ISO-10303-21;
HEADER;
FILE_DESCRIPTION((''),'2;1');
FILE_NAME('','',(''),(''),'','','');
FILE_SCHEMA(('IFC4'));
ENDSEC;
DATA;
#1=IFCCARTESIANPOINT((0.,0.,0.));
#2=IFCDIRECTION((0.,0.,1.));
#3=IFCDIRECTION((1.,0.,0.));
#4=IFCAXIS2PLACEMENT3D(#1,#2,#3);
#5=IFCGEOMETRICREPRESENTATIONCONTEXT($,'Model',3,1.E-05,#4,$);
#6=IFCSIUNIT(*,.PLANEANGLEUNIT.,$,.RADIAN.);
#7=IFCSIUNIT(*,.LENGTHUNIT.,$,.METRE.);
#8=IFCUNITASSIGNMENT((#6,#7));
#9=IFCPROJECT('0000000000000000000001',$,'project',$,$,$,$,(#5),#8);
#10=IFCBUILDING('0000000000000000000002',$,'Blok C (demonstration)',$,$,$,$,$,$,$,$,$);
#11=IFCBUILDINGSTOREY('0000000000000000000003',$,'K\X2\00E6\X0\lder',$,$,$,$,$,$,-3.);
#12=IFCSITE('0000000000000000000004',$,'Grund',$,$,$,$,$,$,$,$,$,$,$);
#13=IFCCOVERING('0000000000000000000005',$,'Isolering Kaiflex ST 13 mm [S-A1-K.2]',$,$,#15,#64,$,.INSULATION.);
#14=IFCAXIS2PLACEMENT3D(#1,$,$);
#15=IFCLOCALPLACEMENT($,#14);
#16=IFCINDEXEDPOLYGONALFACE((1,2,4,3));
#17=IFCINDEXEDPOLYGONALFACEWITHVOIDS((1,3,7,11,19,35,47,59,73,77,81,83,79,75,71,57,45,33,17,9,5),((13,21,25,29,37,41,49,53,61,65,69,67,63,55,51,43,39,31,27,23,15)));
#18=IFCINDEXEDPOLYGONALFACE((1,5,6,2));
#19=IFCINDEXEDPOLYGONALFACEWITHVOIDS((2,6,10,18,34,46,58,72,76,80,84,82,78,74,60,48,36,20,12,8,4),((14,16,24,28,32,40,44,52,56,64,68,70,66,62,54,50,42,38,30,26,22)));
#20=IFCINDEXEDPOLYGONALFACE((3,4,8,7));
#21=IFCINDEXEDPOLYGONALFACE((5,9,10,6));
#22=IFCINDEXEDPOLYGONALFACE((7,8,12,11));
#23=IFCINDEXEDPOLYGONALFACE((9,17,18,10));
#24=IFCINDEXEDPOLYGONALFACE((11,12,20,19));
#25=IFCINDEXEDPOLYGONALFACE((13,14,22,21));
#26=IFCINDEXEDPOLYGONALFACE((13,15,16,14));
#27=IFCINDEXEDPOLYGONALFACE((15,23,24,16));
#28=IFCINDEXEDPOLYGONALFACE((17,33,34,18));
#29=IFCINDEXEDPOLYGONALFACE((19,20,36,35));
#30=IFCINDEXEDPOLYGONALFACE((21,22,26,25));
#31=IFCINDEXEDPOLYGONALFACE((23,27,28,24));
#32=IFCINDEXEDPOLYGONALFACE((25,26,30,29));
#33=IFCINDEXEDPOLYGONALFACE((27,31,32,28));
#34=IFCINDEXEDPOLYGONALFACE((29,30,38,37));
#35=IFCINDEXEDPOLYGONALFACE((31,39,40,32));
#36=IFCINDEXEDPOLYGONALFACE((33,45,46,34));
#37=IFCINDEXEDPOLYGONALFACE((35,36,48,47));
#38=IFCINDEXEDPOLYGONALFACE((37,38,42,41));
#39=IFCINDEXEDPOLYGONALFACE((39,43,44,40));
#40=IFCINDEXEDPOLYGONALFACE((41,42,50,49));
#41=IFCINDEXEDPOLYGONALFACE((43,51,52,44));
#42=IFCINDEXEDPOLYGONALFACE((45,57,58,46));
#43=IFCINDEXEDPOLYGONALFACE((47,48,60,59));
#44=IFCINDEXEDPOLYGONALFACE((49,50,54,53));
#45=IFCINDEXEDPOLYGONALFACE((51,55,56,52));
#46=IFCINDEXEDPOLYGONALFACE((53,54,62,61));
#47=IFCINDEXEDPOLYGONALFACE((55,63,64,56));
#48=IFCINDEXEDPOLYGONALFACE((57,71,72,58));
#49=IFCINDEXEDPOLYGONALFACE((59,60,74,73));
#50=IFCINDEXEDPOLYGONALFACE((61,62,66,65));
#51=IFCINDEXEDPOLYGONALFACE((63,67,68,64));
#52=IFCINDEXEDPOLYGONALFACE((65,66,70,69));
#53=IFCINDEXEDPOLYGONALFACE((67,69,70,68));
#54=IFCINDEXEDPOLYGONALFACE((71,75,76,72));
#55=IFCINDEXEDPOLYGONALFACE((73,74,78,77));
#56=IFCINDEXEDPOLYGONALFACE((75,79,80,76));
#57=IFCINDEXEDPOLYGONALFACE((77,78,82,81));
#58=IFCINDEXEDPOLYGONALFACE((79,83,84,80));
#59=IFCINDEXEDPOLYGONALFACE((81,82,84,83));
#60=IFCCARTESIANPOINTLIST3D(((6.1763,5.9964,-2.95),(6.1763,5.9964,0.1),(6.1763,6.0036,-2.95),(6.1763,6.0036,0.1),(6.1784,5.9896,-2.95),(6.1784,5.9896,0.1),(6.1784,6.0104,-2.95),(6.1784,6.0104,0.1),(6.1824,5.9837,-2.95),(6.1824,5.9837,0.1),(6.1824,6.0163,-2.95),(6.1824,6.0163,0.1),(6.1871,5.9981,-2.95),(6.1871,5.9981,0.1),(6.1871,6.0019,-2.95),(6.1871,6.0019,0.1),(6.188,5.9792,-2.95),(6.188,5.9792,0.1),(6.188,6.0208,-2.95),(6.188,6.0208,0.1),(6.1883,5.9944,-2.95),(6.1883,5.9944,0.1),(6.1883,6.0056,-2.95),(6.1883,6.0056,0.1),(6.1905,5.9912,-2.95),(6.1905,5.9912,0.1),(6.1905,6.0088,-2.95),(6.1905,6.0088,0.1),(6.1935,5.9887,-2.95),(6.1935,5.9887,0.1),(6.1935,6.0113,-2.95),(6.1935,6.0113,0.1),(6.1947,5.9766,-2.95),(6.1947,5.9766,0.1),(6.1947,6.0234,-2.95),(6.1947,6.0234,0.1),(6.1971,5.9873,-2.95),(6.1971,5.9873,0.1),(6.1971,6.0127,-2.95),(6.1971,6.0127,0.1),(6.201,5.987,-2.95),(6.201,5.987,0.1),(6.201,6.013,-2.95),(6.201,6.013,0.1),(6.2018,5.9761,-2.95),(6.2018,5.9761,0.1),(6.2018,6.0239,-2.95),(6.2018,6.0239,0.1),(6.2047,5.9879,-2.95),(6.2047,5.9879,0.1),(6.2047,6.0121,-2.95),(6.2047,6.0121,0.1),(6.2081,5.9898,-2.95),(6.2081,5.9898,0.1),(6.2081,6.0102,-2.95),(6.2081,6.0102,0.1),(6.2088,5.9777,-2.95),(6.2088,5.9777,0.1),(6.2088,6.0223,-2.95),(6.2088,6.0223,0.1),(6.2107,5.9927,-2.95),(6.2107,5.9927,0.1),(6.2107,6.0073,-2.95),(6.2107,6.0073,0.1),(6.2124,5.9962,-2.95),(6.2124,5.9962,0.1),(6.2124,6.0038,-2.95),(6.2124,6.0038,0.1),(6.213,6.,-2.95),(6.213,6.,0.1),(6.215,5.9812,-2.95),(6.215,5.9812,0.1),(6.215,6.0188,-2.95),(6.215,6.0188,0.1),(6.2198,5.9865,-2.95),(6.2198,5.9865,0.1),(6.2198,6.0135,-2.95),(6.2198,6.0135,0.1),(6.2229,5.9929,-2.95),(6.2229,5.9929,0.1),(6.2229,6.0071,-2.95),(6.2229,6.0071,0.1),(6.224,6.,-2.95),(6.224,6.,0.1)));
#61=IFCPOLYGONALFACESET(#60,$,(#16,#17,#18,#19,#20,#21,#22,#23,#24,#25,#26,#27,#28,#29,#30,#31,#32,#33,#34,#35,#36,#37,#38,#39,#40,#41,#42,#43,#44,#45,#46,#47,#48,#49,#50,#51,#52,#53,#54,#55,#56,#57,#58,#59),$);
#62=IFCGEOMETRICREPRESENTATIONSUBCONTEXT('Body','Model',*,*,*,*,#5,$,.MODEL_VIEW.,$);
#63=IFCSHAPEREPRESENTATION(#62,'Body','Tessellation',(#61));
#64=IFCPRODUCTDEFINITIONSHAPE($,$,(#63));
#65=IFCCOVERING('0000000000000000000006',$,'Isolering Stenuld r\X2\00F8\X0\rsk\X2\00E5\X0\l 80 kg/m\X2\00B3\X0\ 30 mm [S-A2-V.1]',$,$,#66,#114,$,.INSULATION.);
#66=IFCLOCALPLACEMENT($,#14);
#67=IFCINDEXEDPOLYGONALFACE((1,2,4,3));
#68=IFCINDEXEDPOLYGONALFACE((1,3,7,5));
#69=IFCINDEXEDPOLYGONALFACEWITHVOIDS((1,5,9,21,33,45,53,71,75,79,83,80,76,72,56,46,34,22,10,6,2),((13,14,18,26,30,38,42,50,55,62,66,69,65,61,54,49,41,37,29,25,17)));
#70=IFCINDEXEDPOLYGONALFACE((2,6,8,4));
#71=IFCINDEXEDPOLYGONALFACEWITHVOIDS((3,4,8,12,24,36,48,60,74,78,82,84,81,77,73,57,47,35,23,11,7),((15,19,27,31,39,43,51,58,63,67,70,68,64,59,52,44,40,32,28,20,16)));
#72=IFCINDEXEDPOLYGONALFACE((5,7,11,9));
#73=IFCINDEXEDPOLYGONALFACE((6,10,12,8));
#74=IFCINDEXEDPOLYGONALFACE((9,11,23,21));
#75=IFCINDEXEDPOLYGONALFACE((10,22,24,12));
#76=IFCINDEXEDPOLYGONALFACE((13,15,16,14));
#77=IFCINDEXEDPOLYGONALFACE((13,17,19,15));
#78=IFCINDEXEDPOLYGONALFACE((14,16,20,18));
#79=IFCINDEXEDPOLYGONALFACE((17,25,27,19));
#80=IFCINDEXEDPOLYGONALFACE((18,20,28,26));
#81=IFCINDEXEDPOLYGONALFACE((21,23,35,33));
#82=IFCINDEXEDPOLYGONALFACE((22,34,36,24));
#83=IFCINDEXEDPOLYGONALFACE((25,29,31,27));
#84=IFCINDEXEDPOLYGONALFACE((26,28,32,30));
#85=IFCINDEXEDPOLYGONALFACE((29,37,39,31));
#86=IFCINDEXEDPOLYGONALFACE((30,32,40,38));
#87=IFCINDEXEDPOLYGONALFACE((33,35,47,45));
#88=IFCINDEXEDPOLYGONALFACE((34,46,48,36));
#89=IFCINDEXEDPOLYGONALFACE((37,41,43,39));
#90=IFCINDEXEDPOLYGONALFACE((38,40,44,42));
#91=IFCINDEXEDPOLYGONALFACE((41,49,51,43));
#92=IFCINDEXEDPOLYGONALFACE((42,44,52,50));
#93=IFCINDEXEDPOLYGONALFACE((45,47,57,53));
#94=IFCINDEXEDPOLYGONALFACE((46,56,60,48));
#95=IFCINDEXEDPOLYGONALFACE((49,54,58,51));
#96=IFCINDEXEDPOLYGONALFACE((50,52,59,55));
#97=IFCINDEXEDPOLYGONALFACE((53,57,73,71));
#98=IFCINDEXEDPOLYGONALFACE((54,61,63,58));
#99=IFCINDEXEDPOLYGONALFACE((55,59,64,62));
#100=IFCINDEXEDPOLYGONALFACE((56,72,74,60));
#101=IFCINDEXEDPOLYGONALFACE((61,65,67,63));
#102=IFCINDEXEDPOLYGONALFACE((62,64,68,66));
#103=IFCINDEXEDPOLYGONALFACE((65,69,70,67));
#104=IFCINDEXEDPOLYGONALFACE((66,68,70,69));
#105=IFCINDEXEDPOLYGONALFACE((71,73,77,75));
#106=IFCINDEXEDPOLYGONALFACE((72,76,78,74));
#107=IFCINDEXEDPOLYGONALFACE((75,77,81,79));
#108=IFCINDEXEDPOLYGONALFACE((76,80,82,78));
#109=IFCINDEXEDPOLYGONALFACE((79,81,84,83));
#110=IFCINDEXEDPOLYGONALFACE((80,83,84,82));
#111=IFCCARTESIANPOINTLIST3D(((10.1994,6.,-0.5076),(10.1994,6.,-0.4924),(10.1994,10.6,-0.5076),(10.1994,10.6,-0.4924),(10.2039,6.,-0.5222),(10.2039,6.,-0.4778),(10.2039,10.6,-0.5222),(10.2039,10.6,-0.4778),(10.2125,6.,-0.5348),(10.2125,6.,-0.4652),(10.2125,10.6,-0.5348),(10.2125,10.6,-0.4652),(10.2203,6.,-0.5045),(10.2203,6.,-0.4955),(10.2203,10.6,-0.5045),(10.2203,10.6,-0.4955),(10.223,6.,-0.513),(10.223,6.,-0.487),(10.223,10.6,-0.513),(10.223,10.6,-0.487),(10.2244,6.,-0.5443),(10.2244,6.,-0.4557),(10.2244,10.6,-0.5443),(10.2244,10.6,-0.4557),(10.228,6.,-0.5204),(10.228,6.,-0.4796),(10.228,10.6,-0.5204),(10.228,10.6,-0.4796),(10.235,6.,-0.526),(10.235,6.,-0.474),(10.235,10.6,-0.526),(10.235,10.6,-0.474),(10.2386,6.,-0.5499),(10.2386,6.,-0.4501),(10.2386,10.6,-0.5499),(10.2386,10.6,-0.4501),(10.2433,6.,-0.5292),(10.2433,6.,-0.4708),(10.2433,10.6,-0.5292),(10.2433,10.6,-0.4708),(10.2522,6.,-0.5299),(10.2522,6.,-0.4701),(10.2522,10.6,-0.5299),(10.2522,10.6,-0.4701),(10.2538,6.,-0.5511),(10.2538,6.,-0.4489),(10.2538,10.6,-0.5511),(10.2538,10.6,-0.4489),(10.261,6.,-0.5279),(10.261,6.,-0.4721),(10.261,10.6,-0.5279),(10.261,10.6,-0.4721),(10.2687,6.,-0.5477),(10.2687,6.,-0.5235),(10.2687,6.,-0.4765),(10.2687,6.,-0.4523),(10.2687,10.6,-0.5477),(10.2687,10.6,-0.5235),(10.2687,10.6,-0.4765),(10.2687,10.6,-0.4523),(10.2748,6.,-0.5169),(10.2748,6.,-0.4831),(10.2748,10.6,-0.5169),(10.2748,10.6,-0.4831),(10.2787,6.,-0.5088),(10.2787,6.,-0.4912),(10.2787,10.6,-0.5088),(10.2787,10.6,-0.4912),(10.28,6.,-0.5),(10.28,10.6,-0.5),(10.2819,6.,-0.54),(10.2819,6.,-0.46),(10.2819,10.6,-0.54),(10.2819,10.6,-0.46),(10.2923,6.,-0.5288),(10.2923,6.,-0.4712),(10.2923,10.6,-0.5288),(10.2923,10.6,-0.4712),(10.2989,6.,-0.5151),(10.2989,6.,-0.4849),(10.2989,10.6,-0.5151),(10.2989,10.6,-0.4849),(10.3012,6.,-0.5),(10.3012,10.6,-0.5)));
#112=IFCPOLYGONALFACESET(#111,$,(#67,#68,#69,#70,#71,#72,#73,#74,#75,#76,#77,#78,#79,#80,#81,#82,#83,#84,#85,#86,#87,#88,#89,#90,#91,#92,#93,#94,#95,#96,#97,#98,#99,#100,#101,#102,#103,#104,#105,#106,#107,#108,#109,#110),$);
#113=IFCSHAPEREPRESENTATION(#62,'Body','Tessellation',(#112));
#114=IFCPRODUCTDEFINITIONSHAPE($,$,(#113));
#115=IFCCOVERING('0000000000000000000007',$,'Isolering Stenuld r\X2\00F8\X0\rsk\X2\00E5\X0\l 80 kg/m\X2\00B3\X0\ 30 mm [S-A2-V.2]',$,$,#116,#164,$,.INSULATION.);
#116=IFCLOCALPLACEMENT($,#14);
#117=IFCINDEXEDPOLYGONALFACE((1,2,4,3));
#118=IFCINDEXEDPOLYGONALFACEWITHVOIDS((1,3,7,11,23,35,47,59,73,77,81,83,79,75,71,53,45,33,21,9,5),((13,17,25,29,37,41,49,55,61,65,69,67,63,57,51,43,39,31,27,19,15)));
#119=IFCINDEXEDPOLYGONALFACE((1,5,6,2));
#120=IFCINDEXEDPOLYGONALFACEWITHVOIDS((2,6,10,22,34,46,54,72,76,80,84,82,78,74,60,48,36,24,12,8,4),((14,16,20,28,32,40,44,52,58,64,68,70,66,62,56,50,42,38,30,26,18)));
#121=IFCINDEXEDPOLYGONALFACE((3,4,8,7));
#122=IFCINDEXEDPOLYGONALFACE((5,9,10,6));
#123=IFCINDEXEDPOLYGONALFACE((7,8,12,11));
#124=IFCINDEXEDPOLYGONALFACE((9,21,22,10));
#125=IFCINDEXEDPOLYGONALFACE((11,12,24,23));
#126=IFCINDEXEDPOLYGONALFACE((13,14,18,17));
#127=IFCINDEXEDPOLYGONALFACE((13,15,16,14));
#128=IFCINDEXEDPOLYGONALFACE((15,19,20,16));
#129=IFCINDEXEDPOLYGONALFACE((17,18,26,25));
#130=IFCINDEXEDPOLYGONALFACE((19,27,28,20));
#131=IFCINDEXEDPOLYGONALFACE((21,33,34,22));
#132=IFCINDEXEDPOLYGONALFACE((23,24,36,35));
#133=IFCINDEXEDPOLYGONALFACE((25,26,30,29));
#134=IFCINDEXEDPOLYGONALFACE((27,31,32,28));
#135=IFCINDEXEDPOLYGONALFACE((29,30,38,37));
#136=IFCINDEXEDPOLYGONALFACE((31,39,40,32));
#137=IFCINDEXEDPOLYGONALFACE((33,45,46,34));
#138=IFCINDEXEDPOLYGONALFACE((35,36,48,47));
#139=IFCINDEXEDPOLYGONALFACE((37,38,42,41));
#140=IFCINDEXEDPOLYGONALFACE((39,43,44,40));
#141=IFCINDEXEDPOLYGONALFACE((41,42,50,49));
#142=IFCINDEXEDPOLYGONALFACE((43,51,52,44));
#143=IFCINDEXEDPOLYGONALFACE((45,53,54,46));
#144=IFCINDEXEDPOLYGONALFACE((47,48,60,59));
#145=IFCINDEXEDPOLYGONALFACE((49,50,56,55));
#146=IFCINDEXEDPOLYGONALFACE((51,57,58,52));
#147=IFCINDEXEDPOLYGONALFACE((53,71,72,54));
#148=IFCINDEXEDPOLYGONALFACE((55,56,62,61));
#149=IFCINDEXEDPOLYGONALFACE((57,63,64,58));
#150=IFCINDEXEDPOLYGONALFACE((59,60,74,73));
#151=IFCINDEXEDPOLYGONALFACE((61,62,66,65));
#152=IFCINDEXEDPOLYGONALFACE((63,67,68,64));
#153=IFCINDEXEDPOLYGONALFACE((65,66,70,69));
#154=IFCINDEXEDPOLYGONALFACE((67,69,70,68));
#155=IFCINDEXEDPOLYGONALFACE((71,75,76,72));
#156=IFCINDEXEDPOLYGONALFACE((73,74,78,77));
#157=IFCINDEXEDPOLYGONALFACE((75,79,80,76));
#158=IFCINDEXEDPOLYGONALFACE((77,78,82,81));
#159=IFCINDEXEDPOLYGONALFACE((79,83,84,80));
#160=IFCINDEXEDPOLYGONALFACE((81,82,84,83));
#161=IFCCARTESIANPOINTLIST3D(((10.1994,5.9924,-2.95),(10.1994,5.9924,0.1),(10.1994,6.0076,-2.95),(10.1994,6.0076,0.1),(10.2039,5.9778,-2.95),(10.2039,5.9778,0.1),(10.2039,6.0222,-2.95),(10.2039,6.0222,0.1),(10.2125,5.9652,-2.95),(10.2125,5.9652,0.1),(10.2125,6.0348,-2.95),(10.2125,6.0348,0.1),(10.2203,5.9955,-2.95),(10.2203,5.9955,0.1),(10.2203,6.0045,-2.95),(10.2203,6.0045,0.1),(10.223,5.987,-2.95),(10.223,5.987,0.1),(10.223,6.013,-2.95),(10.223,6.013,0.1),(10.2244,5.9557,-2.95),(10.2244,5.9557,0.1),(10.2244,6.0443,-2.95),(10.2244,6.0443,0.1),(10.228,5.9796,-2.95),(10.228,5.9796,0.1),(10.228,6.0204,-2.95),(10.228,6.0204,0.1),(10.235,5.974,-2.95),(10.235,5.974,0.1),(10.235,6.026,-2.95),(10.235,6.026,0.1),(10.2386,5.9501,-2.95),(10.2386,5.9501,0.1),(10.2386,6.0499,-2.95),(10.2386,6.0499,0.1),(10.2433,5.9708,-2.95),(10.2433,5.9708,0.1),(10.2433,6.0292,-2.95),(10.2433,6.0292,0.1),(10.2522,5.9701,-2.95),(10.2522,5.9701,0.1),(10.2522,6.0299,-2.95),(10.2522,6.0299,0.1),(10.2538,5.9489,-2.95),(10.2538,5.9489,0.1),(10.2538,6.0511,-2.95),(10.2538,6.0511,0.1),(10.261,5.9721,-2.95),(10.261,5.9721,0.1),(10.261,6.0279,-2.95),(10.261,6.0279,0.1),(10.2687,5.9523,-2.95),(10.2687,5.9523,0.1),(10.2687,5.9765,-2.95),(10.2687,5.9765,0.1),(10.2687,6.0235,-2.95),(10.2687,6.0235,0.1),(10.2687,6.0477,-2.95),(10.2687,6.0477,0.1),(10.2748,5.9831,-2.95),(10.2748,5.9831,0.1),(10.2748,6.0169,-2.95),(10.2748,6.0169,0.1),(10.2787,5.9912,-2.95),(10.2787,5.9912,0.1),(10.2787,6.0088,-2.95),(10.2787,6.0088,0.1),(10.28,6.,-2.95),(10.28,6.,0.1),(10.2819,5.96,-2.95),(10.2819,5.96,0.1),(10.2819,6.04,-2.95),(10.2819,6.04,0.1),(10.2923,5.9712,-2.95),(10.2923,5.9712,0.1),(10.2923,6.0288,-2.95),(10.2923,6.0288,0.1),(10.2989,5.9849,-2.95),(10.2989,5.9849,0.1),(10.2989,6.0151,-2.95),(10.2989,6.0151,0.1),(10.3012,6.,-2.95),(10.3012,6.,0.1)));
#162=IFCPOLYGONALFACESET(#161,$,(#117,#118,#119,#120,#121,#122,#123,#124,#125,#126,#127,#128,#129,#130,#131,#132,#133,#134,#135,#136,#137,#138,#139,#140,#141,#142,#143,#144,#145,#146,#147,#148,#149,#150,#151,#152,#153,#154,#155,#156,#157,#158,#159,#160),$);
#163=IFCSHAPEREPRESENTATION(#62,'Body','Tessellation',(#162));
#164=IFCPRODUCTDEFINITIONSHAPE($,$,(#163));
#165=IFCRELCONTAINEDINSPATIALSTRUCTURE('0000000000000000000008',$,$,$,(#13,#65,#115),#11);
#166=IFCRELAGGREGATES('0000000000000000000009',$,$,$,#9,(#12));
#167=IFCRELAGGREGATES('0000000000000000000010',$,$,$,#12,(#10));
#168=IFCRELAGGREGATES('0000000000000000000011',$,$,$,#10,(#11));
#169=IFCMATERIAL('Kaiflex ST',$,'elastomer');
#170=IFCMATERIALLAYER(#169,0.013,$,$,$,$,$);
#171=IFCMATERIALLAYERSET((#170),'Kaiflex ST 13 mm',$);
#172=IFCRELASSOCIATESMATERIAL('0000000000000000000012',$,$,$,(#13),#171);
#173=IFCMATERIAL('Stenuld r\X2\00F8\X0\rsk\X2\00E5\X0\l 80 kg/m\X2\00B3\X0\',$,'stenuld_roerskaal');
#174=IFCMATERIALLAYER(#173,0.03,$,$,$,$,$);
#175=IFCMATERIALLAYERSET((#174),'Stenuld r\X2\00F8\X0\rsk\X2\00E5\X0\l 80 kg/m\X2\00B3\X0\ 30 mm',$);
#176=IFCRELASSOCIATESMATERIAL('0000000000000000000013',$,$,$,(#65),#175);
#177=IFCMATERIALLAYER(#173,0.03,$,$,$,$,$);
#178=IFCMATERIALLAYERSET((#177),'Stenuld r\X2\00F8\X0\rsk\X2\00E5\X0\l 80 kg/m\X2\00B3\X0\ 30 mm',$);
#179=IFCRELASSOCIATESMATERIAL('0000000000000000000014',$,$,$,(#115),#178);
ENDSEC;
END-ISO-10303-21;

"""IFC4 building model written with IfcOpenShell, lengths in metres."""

from ifc_helpers import new_model, si_unit, frame, origin_with_axes, place, context, subcontext, project, spatial, hollow_circle, extrude, material, layer, layer_set, element, save


model = new_model("IFC4")

# Units and contexts
model_context = context("Model", 3, precision=1e-05, world=origin_with_axes())
body_context = subcontext(model_context, "Body", "Model", "MODEL_VIEW")
ifc_project = project(units=[si_unit("PLANEANGLEUNIT", "RADIAN"), si_unit("LENGTHUNIT", "METRE")], contexts=[model_context])

# Site, building, storey
site = spatial("IfcSite", under=ifc_project, Name="Grund")
building = spatial("IfcBuilding", under=site, Name="Blok C (demonstration)")
storey = spatial("IfcBuildingStorey", under=building, Name="Kælder", Elevation=-3.0)

# Coverings
ifc_material_1 = material(Name="Stenuld rørskål 80 kg/m³", Category="stenuld_roerskaal")
ifc_material_2 = material(Name="Kaiflex ST", Category="elastomer")
ifc_layer_1 = layer(ifc_material_2, 0.013)
ifc_layer_set_1 = layer_set([ifc_layer_1], Name="Kaiflex ST 13 mm")
covering_1_placement = place(None, origin_with_axes())
element("IfcCovering", 1, at=covering_1_placement, inside=storey, material=ifc_layer_set_1, Name="Isolering Kaiflex ST 13 mm [S-A1-K.2]", PredefinedType="INSULATION", context=body_context, shape_type="SweptSolid", body=[
    extrude(hollow_circle(Radius=0.024, WallThickness=0.011), frame((6.2, 6.0, -2.95), z_axis=(0.0, 0.0, 1.0), x_axis=(1.0, 0.0, 0.0)), (0.0, 0.0, 1.0), 3.05),
])
ifc_layer_2 = layer(ifc_material_1, 0.03)
ifc_layer_set_2 = layer_set([ifc_layer_2], Name="Stenuld rørskål 80 kg/m³ 30 mm")
covering_2_placement = place(None, origin_with_axes())
element("IfcCovering", 2, at=covering_2_placement, inside=storey, material=ifc_layer_set_2, Name="Isolering Stenuld rørskål 80 kg/m³ 30 mm [S-A2-V.1]", PredefinedType="INSULATION", context=body_context, shape_type="SweptSolid", body=[
    extrude(hollow_circle(Radius=0.0512, WallThickness=0.0212), frame((10.25, 10.6, -0.5), z_axis=(0.0, -1.0, 0.0), x_axis=(1.0, 0.0, 0.0)), (0.0, 0.0, 1.0), 4.6),
])
ifc_layer_3 = layer(ifc_material_1, 0.03)
ifc_layer_set_3 = layer_set([ifc_layer_3], Name="Stenuld rørskål 80 kg/m³ 30 mm")
covering_3_placement = place(None, origin_with_axes())
element("IfcCovering", 3, at=covering_3_placement, inside=storey, material=ifc_layer_set_3, Name="Isolering Stenuld rørskål 80 kg/m³ 30 mm [S-A2-V.2]", PredefinedType="INSULATION", context=body_context, shape_type="SweptSolid", body=[
    extrude(hollow_circle(Radius=0.0512, WallThickness=0.0212), frame((10.25, 6.0, -2.95), z_axis=(0.0, 0.0, 1.0), x_axis=(1.0, 0.0, 0.0)), (0.0, 0.0, 1.0), 3.05),
])

save(model, "model.ifc")
